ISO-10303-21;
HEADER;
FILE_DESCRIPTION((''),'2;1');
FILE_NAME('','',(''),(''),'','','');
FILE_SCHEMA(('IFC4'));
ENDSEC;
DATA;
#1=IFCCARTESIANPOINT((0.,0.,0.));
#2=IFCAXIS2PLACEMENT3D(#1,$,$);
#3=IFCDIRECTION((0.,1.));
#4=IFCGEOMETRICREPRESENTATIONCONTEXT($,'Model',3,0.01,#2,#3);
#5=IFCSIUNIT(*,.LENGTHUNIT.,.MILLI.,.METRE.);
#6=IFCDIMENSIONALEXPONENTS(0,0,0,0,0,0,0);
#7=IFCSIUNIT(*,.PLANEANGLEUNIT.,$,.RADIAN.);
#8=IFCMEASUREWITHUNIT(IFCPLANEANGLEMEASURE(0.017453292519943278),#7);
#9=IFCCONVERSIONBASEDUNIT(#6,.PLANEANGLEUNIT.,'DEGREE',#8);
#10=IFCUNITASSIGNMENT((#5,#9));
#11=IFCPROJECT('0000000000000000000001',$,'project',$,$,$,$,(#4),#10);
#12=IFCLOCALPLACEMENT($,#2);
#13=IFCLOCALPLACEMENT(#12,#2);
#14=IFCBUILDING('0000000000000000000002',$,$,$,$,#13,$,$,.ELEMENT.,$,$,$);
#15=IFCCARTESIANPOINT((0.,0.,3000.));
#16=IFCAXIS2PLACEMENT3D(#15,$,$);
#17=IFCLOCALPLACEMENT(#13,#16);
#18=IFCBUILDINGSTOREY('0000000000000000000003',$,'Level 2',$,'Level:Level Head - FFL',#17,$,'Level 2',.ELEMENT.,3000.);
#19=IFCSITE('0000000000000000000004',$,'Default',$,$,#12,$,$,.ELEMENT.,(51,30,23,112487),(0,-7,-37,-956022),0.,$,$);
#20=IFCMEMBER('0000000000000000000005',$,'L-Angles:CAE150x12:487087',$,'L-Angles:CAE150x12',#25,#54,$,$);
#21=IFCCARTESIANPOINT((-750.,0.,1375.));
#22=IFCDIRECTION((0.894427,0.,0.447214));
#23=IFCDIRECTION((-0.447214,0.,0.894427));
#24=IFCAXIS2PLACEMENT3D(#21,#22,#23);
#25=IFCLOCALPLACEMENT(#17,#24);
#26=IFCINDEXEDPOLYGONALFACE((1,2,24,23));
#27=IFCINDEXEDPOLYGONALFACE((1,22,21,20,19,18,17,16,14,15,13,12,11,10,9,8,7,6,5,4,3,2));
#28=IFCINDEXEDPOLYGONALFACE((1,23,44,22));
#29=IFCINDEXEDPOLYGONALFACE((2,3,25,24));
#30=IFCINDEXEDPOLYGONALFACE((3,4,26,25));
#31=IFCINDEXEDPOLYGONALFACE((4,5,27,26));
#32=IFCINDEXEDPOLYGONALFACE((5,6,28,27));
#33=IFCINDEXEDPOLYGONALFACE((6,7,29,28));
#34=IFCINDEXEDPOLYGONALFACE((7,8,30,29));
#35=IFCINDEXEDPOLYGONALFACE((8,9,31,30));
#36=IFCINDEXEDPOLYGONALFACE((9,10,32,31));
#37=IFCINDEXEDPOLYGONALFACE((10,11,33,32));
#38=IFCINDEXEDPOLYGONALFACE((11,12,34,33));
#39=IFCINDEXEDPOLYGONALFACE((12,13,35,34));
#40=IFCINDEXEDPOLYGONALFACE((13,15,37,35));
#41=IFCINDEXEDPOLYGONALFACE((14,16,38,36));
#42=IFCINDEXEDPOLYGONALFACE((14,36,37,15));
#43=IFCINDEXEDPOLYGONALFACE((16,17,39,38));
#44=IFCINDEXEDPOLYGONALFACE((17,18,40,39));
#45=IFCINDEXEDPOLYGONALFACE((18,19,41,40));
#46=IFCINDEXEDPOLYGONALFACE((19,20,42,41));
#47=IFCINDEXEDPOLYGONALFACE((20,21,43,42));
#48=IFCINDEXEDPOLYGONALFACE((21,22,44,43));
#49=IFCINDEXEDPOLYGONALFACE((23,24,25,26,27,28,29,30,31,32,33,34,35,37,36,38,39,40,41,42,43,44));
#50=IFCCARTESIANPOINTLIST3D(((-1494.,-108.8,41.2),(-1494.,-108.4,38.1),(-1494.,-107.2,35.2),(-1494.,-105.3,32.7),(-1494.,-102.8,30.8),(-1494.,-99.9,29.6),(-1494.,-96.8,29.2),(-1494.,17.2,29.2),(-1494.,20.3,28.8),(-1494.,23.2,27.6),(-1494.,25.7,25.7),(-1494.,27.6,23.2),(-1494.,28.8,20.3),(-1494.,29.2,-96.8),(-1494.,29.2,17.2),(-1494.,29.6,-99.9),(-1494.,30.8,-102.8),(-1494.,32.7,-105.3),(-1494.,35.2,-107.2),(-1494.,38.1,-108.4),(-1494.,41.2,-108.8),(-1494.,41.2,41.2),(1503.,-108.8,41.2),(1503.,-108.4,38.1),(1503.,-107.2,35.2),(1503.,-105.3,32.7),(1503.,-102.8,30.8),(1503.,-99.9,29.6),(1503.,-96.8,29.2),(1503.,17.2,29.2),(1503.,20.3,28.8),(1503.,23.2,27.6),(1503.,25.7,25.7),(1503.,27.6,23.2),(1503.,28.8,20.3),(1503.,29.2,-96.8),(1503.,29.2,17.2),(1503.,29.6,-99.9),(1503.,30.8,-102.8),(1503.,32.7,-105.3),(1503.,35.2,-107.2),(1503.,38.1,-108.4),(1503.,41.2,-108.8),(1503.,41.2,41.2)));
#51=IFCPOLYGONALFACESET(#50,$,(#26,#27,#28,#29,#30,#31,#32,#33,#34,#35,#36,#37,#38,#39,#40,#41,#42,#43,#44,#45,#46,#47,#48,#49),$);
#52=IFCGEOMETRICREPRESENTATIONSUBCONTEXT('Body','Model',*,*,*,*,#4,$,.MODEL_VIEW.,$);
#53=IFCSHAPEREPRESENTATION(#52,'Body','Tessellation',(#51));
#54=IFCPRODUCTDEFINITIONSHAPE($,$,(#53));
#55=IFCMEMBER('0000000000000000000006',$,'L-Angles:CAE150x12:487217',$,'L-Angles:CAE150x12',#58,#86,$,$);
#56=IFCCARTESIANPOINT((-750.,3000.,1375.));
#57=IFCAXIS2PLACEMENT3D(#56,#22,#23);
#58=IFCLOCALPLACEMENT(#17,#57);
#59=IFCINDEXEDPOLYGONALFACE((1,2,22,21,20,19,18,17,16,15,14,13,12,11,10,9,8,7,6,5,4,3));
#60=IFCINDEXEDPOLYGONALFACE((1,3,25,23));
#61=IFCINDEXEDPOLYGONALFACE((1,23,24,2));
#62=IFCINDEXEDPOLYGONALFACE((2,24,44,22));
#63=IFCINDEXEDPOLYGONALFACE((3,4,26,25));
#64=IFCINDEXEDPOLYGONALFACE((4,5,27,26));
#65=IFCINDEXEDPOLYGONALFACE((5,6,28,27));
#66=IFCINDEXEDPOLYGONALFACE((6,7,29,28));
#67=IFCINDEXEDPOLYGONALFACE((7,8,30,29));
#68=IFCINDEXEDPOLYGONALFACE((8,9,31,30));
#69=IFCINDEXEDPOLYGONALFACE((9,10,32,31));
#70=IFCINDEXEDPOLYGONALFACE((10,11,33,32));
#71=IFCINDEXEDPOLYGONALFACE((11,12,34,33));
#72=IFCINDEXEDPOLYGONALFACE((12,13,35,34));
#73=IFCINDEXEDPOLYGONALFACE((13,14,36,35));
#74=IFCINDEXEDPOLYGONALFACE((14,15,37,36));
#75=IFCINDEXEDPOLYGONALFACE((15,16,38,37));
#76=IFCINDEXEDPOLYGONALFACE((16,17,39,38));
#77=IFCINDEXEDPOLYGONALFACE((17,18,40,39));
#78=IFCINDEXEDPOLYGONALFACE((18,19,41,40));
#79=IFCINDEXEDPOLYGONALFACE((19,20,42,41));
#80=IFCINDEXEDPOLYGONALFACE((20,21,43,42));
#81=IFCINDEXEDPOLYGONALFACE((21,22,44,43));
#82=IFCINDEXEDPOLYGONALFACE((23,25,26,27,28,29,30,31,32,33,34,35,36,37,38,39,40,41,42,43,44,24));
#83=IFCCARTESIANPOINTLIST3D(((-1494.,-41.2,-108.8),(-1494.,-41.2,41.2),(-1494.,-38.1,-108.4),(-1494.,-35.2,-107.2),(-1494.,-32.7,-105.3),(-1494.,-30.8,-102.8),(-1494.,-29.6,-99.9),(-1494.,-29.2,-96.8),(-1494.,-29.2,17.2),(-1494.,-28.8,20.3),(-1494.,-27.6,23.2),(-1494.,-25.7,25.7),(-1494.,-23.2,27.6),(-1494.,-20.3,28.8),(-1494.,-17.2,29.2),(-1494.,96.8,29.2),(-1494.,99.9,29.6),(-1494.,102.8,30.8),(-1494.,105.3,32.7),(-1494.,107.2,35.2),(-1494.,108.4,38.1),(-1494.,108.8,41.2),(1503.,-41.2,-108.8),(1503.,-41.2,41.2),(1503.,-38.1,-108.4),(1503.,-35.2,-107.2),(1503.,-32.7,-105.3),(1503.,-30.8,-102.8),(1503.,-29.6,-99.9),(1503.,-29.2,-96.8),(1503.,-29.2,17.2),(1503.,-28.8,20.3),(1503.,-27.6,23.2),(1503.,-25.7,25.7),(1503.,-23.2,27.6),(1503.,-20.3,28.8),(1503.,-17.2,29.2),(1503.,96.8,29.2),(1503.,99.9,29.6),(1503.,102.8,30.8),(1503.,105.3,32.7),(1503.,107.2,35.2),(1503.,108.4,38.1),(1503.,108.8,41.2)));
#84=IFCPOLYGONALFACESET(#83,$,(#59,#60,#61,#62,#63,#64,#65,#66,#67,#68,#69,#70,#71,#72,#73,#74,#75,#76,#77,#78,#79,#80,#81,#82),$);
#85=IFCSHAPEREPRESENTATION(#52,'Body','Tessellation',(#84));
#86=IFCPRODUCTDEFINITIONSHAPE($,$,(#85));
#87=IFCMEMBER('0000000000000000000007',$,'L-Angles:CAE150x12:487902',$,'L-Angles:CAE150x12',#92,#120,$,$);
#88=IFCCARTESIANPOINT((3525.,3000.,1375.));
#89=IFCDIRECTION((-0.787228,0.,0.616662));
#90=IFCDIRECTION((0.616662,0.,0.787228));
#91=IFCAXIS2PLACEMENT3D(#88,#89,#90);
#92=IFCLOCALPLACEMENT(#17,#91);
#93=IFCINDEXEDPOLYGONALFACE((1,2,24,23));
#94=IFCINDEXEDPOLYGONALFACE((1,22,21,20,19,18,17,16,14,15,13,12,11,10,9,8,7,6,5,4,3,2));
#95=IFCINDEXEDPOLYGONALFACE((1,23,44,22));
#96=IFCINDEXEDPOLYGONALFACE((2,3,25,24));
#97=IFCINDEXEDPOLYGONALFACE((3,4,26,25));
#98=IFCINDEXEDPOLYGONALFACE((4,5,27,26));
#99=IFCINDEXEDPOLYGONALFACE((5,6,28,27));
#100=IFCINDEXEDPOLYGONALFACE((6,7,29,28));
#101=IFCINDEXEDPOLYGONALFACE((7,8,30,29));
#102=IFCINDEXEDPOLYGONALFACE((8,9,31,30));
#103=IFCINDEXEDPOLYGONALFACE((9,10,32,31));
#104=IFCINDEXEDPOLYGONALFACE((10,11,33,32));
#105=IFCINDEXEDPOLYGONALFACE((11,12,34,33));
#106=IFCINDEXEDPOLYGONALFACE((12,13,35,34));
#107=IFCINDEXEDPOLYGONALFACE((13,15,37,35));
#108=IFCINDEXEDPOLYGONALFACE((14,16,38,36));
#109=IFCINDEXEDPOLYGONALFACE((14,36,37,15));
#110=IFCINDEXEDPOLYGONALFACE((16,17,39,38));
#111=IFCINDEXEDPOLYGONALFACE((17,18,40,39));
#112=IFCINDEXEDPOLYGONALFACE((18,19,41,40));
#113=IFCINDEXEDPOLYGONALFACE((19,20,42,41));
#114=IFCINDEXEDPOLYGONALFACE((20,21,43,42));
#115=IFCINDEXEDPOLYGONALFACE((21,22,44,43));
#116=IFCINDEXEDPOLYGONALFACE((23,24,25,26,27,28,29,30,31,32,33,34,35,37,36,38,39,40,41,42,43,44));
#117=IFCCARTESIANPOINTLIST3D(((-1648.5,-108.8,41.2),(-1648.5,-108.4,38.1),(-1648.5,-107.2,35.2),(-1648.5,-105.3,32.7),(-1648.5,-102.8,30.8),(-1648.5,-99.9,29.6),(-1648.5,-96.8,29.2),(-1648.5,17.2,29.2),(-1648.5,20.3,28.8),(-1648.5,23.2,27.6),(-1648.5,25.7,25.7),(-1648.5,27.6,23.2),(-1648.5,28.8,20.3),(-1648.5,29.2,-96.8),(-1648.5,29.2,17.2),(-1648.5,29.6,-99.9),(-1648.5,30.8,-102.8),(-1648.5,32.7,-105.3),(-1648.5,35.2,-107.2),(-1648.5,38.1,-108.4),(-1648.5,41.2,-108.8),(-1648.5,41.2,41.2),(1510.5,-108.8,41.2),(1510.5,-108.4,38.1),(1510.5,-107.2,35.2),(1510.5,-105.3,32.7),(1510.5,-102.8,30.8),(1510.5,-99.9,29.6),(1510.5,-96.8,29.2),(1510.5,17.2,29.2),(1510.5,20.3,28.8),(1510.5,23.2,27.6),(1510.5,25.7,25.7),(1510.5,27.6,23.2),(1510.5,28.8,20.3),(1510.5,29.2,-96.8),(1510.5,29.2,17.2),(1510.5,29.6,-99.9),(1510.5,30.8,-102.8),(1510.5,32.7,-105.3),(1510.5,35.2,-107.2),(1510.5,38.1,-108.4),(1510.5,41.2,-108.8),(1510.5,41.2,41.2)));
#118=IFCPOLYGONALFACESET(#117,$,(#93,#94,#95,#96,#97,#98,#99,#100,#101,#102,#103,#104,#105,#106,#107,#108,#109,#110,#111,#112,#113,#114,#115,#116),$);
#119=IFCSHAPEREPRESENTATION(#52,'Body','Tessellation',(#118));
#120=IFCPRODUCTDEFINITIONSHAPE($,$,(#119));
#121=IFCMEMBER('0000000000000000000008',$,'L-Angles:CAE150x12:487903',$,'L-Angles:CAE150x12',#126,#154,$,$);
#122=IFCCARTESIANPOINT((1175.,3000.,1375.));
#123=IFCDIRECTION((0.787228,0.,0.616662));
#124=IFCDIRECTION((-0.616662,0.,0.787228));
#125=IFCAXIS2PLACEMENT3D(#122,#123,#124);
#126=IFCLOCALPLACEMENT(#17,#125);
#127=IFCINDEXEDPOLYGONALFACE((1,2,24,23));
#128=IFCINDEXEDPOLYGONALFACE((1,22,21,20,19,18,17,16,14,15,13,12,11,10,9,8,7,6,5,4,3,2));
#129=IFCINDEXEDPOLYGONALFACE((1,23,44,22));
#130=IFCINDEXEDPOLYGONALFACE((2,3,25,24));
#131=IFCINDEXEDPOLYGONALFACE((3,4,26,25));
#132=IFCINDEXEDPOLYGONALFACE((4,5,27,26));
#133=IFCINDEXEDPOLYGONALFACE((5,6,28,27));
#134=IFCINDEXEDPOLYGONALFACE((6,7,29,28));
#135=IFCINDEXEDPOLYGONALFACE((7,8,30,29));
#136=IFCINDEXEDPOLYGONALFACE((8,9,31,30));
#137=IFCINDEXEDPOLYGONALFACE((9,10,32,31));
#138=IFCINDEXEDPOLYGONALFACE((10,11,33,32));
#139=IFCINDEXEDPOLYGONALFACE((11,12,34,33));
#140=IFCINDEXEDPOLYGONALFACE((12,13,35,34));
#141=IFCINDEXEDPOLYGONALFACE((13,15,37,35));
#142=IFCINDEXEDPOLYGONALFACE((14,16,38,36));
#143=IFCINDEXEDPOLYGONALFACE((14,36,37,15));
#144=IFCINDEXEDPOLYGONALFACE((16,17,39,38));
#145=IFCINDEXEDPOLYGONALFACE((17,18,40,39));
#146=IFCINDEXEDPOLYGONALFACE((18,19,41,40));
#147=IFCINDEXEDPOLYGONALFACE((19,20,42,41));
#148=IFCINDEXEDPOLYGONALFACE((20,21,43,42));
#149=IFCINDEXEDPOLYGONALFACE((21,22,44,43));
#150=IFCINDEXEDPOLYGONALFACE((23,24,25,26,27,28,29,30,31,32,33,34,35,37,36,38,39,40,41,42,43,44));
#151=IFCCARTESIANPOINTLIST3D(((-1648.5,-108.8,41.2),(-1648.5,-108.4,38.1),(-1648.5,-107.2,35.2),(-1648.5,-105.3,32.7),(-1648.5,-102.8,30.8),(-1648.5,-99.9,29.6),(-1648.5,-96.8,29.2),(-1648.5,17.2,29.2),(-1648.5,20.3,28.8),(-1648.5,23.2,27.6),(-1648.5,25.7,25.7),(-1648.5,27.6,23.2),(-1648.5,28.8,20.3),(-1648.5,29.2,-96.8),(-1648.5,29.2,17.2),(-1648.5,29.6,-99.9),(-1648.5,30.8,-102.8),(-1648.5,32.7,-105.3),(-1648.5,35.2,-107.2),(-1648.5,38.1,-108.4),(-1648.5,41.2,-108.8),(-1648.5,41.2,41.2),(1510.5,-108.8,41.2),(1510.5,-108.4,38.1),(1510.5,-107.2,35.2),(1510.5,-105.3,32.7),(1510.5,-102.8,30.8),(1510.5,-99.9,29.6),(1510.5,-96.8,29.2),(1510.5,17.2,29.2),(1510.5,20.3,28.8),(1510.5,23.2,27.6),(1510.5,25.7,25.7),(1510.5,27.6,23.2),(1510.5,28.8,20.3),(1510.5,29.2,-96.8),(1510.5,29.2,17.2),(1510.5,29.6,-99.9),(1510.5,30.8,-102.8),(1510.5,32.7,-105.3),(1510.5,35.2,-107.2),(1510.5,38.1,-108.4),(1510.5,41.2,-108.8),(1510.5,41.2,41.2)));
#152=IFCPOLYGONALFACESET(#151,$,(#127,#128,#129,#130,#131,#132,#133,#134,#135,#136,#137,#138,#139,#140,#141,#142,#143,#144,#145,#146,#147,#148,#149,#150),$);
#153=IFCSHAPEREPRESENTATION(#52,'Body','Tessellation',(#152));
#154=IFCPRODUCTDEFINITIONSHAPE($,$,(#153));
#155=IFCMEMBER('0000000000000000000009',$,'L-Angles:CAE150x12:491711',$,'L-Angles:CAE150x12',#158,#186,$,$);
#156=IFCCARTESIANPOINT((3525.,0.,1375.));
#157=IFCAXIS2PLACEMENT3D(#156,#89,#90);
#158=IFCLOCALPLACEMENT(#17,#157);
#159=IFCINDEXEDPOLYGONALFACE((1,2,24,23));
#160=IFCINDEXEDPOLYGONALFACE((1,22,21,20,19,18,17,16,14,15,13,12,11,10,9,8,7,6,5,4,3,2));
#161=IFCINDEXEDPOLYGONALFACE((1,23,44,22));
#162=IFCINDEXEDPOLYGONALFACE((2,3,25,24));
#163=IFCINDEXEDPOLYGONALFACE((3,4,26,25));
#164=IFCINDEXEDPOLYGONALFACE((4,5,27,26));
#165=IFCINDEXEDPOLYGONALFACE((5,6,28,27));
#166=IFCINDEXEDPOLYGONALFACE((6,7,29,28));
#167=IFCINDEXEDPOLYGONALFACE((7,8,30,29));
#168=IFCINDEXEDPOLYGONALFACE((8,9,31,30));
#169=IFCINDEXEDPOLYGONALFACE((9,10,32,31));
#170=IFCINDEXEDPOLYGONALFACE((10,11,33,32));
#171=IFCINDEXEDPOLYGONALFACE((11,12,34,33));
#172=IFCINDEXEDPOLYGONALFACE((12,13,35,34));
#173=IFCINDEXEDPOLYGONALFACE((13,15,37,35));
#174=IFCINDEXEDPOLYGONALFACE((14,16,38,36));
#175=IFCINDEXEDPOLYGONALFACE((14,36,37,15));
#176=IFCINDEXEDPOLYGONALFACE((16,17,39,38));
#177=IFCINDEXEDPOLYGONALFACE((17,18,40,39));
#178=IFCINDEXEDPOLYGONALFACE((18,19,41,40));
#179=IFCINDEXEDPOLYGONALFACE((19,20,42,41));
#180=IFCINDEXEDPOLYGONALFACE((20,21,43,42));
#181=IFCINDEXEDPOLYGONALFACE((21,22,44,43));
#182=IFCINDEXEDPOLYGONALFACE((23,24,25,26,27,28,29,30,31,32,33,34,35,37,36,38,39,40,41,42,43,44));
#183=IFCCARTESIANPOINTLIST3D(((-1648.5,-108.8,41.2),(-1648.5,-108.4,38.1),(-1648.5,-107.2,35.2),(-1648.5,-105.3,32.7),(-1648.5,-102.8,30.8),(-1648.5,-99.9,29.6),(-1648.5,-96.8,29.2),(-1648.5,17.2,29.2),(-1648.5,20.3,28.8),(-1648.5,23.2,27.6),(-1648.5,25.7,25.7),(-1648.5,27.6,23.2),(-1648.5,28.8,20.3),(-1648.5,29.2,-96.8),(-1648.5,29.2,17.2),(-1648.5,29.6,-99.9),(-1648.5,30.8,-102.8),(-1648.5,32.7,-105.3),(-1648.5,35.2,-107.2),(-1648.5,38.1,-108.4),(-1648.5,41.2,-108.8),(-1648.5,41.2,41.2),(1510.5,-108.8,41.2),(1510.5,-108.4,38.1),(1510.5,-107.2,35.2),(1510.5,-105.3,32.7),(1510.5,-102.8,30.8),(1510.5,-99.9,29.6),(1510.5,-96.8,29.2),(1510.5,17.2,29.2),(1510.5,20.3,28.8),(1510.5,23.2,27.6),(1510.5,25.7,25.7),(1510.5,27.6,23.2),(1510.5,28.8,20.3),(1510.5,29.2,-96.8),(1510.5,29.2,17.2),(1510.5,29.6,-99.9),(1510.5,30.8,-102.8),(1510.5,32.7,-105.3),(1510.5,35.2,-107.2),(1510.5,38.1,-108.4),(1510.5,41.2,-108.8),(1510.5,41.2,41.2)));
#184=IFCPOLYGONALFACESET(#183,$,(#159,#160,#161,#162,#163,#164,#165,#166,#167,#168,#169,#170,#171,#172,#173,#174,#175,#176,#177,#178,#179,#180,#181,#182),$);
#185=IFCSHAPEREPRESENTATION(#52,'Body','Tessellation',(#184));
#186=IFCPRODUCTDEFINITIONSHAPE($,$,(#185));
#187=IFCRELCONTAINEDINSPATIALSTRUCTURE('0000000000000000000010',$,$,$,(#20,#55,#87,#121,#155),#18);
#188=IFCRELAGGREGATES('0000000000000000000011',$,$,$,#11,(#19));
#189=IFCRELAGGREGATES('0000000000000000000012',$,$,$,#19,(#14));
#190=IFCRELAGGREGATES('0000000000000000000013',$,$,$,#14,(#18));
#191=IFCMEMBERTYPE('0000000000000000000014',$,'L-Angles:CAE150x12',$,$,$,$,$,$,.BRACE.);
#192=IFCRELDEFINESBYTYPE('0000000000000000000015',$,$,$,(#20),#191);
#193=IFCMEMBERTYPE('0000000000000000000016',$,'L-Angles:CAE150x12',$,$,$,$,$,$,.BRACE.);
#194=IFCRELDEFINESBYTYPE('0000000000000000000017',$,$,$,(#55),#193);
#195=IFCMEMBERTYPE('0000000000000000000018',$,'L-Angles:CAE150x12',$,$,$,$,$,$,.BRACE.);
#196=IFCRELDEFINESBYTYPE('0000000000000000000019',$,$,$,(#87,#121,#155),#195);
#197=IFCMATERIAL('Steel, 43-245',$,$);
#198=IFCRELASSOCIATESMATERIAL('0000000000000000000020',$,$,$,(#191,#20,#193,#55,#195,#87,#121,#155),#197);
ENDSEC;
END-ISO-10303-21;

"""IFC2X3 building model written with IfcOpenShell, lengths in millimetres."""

from ifc_helpers import new_model, entity, si_unit, converted_unit, direction, frame, frame_2d, origin, place, context, subcontext, project, spatial, polyline, circle_curve, parameter, trimmed, segment, composite_curve, outline, extrude, source, transform, mapped, material, type_object, type_shapes, element, save


model = new_model("IFC2X3")

# Units and contexts
model_context = context("Model", 3, precision=0.01, world=origin(), true_north=direction((0.0, 1.0)))
body_context = subcontext(model_context, "Body", "Model", "MODEL_VIEW")
ifc_project = project(units=[si_unit("LENGTHUNIT", "METRE", prefix="MILLI"), converted_unit("PLANEANGLEUNIT", "DEGREE", entity("IfcPlaneAngleMeasure", 0.017453292519943278), si_unit("PLANEANGLEUNIT", "RADIAN"), dimensions=[0, 0, 0, 0, 0, 0, 0])], contexts=[model_context])

# Site, building, storey
site_placement = place(None, origin())
site = spatial("IfcSite", under=ifc_project, at=site_placement, Name="Default", CompositionType="ELEMENT", RefLatitude=(51, 30, 23, 112487), RefLongitude=(0, -7, -37, -956022), RefElevation=0.0)
building_placement = place(site_placement, origin())
building = spatial("IfcBuilding", under=site, at=building_placement, CompositionType="ELEMENT")
storey_placement = place(building_placement, frame((0.0, 0.0, 3000.0)))
storey = spatial("IfcBuildingStorey", under=building, at=storey_placement, Name="Level 2", ObjectType="Level:Level Head - FFL", LongName="Level 2", CompositionType="ELEMENT", Elevation=3000.0)

# Shared definitions
ifc_material = material(Name="Steel, 43-245")

# Members
member_type_1 = type_object("IfcMemberType", Name="L-Angles:CAE150x12", PredefinedType="BRACE", material=ifc_material)
shared_shape_1 = source(origin(), body_context, "Body", "SweptSolid", [
    extrude(outline(composite_curve([segment(polyline([(-102.0, -48.0), (48.0, -48.0)]), True, "CONTINUOUS"), segment(polyline([(48.0, -48.0), (48.0, 102.0)]), True, "CONTINUOUS"), segment(trimmed(circle_curve(frame_2d((48.0, 90.0), x_axis=(0.0, 1.0)), 12.0), [parameter(0.0)], [parameter(90.0)], True, "PARAMETER"), True, "CONTINUOUS"), segment(polyline([(36.0, 90.0), (36.0, -24.0)]), True, "CONTINUOUS"), segment(trimmed(circle_curve(frame_2d((24.0, -24.0), x_axis=(1.0, 0.0)), 12.0), [parameter(270.0)], [parameter(0.0)], True, "PARAMETER"), False, "CONTINUOUS"), segment(polyline([(24.0, -36.0), (-90.0, -36.0)]), True, "CONTINUOUS"), segment(trimmed(circle_curve(frame_2d((-90.0, -48.0), x_axis=(0.0, 1.0)), 12.0), [parameter(0.0)], [parameter(90.0)], True, "PARAMETER"), True, "CONTINUOUS")], self_intersect=False)), frame((-1494.0, -6.8, -6.8), z_axis=(1.0, 0.0, 0.0), x_axis=(0.0, 0.0, 1.0)), (0.0, 0.0, 1.0), 2997.0),
])
type_shapes(member_type_1, [shared_shape_1])
member_1_placement = place(storey_placement, frame((-750.0, 0.0, 1375.0), z_axis=(0.894427, 0.0, 0.447214), x_axis=(-0.447214, 0.0, 0.894427)))
element("IfcMember", 1, at=member_1_placement, inside=storey, type_object=member_type_1, material=ifc_material, Name="L-Angles:CAE150x12:487087", ObjectType="L-Angles:CAE150x12", context=body_context, shape_type="MappedRepresentation", body=[
    mapped(shared_shape_1, transform((0.0, 0.0, 0.0), scale=1.0)),
])
member_type_2 = type_object("IfcMemberType", Name="L-Angles:CAE150x12", PredefinedType="BRACE", material=ifc_material)
shared_shape_2 = source(origin(), body_context, "Body", "SweptSolid", [
    extrude(outline(composite_curve([segment(polyline([(-48.0, -48.0), (102.0, -48.0)]), True, "CONTINUOUS"), segment(trimmed(circle_curve(frame_2d((90.0, -48.0), x_axis=(1.0, 0.0)), 12.0), [parameter(0.0)], [parameter(90.0)], True, "PARAMETER"), True, "CONTINUOUS"), segment(polyline([(90.0, -36.0), (-24.0, -36.0)]), True, "CONTINUOUS"), segment(trimmed(circle_curve(frame_2d((-24.0, -24.0), x_axis=(0.0, -1.0)), 12.0), [parameter(270.0)], [parameter(0.0)], True, "PARAMETER"), False, "CONTINUOUS"), segment(polyline([(-36.0, -24.0), (-36.0, 90.0)]), True, "CONTINUOUS"), segment(trimmed(circle_curve(frame_2d((-48.0, 90.0), x_axis=(1.0, 0.0)), 12.0), [parameter(0.0)], [parameter(90.0)], True, "PARAMETER"), True, "CONTINUOUS"), segment(polyline([(-48.0, 102.0), (-48.0, -48.0)]), True, "CONTINUOUS")], self_intersect=False)), frame((-1494.0, 6.8, -6.8), z_axis=(1.0, 0.0, 0.0), x_axis=(0.0, 0.0, -1.0)), (0.0, 0.0, 1.0), 2997.0),
])
type_shapes(member_type_2, [shared_shape_2])
member_2_placement = place(storey_placement, frame((-750.0, 3000.0, 1375.0), z_axis=(0.894427, 0.0, 0.447214), x_axis=(-0.447214, 0.0, 0.894427)))
element("IfcMember", 2, at=member_2_placement, inside=storey, type_object=member_type_2, material=ifc_material, Name="L-Angles:CAE150x12:487217", ObjectType="L-Angles:CAE150x12", context=body_context, shape_type="MappedRepresentation", body=[
    mapped(shared_shape_2, transform((0.0, 0.0, 0.0), scale=1.0)),
])
member_type_3 = type_object("IfcMemberType", Name="L-Angles:CAE150x12", PredefinedType="BRACE", material=ifc_material)
shared_shape_3 = source(origin(), body_context, "Body", "SweptSolid", [
    extrude(outline(composite_curve([segment(polyline([(-102.0, -48.0), (48.0, -48.0)]), True, "CONTINUOUS"), segment(polyline([(48.0, -48.0), (48.0, 102.0)]), True, "CONTINUOUS"), segment(trimmed(circle_curve(frame_2d((48.0, 90.0), x_axis=(0.0, 1.0)), 12.0), [parameter(0.0)], [parameter(90.0)], True, "PARAMETER"), True, "CONTINUOUS"), segment(polyline([(36.0, 90.0), (36.0, -24.0)]), True, "CONTINUOUS"), segment(trimmed(circle_curve(frame_2d((24.0, -24.0), x_axis=(1.0, 0.0)), 12.0), [parameter(270.0)], [parameter(0.0)], True, "PARAMETER"), False, "CONTINUOUS"), segment(polyline([(24.0, -36.0), (-90.0, -36.0)]), True, "CONTINUOUS"), segment(trimmed(circle_curve(frame_2d((-90.0, -48.0), x_axis=(0.0, 1.0)), 12.0), [parameter(0.0)], [parameter(90.0)], True, "PARAMETER"), True, "CONTINUOUS")], self_intersect=False)), frame((-1648.5, -6.8, -6.8), z_axis=(1.0, 0.0, 0.0), x_axis=(0.0, 0.0, 1.0)), (0.0, 0.0, 1.0), 3159.0),
])
type_shapes(member_type_3, [shared_shape_3])
for number, where, z_axis, x_axis, name in (
    (3, (3525.0, 3000.0, 1375.0), (-0.787228, 0.0, 0.616662), (0.616662, 0.0, 0.787228), "L-Angles:CAE150x12:487902"),
    (4, (1175.0, 3000.0, 1375.0), (0.787228, 0.0, 0.616662), (-0.616662, 0.0, 0.787228), "L-Angles:CAE150x12:487903"),
    (5, (3525.0, 0.0, 1375.0), (-0.787228, 0.0, 0.616662), (0.616662, 0.0, 0.787228), "L-Angles:CAE150x12:491711"),
):
    element("IfcMember", number, at=place(storey_placement, frame(where, z_axis=z_axis, x_axis=x_axis)), inside=storey, type_object=member_type_3, material=ifc_material, Name=name, ObjectType="L-Angles:CAE150x12", context=body_context, shape_type="MappedRepresentation", body=[
        mapped(shared_shape_3, transform((0.0, 0.0, 0.0), scale=1.0)),
    ])

save(model, "model.ifc")
